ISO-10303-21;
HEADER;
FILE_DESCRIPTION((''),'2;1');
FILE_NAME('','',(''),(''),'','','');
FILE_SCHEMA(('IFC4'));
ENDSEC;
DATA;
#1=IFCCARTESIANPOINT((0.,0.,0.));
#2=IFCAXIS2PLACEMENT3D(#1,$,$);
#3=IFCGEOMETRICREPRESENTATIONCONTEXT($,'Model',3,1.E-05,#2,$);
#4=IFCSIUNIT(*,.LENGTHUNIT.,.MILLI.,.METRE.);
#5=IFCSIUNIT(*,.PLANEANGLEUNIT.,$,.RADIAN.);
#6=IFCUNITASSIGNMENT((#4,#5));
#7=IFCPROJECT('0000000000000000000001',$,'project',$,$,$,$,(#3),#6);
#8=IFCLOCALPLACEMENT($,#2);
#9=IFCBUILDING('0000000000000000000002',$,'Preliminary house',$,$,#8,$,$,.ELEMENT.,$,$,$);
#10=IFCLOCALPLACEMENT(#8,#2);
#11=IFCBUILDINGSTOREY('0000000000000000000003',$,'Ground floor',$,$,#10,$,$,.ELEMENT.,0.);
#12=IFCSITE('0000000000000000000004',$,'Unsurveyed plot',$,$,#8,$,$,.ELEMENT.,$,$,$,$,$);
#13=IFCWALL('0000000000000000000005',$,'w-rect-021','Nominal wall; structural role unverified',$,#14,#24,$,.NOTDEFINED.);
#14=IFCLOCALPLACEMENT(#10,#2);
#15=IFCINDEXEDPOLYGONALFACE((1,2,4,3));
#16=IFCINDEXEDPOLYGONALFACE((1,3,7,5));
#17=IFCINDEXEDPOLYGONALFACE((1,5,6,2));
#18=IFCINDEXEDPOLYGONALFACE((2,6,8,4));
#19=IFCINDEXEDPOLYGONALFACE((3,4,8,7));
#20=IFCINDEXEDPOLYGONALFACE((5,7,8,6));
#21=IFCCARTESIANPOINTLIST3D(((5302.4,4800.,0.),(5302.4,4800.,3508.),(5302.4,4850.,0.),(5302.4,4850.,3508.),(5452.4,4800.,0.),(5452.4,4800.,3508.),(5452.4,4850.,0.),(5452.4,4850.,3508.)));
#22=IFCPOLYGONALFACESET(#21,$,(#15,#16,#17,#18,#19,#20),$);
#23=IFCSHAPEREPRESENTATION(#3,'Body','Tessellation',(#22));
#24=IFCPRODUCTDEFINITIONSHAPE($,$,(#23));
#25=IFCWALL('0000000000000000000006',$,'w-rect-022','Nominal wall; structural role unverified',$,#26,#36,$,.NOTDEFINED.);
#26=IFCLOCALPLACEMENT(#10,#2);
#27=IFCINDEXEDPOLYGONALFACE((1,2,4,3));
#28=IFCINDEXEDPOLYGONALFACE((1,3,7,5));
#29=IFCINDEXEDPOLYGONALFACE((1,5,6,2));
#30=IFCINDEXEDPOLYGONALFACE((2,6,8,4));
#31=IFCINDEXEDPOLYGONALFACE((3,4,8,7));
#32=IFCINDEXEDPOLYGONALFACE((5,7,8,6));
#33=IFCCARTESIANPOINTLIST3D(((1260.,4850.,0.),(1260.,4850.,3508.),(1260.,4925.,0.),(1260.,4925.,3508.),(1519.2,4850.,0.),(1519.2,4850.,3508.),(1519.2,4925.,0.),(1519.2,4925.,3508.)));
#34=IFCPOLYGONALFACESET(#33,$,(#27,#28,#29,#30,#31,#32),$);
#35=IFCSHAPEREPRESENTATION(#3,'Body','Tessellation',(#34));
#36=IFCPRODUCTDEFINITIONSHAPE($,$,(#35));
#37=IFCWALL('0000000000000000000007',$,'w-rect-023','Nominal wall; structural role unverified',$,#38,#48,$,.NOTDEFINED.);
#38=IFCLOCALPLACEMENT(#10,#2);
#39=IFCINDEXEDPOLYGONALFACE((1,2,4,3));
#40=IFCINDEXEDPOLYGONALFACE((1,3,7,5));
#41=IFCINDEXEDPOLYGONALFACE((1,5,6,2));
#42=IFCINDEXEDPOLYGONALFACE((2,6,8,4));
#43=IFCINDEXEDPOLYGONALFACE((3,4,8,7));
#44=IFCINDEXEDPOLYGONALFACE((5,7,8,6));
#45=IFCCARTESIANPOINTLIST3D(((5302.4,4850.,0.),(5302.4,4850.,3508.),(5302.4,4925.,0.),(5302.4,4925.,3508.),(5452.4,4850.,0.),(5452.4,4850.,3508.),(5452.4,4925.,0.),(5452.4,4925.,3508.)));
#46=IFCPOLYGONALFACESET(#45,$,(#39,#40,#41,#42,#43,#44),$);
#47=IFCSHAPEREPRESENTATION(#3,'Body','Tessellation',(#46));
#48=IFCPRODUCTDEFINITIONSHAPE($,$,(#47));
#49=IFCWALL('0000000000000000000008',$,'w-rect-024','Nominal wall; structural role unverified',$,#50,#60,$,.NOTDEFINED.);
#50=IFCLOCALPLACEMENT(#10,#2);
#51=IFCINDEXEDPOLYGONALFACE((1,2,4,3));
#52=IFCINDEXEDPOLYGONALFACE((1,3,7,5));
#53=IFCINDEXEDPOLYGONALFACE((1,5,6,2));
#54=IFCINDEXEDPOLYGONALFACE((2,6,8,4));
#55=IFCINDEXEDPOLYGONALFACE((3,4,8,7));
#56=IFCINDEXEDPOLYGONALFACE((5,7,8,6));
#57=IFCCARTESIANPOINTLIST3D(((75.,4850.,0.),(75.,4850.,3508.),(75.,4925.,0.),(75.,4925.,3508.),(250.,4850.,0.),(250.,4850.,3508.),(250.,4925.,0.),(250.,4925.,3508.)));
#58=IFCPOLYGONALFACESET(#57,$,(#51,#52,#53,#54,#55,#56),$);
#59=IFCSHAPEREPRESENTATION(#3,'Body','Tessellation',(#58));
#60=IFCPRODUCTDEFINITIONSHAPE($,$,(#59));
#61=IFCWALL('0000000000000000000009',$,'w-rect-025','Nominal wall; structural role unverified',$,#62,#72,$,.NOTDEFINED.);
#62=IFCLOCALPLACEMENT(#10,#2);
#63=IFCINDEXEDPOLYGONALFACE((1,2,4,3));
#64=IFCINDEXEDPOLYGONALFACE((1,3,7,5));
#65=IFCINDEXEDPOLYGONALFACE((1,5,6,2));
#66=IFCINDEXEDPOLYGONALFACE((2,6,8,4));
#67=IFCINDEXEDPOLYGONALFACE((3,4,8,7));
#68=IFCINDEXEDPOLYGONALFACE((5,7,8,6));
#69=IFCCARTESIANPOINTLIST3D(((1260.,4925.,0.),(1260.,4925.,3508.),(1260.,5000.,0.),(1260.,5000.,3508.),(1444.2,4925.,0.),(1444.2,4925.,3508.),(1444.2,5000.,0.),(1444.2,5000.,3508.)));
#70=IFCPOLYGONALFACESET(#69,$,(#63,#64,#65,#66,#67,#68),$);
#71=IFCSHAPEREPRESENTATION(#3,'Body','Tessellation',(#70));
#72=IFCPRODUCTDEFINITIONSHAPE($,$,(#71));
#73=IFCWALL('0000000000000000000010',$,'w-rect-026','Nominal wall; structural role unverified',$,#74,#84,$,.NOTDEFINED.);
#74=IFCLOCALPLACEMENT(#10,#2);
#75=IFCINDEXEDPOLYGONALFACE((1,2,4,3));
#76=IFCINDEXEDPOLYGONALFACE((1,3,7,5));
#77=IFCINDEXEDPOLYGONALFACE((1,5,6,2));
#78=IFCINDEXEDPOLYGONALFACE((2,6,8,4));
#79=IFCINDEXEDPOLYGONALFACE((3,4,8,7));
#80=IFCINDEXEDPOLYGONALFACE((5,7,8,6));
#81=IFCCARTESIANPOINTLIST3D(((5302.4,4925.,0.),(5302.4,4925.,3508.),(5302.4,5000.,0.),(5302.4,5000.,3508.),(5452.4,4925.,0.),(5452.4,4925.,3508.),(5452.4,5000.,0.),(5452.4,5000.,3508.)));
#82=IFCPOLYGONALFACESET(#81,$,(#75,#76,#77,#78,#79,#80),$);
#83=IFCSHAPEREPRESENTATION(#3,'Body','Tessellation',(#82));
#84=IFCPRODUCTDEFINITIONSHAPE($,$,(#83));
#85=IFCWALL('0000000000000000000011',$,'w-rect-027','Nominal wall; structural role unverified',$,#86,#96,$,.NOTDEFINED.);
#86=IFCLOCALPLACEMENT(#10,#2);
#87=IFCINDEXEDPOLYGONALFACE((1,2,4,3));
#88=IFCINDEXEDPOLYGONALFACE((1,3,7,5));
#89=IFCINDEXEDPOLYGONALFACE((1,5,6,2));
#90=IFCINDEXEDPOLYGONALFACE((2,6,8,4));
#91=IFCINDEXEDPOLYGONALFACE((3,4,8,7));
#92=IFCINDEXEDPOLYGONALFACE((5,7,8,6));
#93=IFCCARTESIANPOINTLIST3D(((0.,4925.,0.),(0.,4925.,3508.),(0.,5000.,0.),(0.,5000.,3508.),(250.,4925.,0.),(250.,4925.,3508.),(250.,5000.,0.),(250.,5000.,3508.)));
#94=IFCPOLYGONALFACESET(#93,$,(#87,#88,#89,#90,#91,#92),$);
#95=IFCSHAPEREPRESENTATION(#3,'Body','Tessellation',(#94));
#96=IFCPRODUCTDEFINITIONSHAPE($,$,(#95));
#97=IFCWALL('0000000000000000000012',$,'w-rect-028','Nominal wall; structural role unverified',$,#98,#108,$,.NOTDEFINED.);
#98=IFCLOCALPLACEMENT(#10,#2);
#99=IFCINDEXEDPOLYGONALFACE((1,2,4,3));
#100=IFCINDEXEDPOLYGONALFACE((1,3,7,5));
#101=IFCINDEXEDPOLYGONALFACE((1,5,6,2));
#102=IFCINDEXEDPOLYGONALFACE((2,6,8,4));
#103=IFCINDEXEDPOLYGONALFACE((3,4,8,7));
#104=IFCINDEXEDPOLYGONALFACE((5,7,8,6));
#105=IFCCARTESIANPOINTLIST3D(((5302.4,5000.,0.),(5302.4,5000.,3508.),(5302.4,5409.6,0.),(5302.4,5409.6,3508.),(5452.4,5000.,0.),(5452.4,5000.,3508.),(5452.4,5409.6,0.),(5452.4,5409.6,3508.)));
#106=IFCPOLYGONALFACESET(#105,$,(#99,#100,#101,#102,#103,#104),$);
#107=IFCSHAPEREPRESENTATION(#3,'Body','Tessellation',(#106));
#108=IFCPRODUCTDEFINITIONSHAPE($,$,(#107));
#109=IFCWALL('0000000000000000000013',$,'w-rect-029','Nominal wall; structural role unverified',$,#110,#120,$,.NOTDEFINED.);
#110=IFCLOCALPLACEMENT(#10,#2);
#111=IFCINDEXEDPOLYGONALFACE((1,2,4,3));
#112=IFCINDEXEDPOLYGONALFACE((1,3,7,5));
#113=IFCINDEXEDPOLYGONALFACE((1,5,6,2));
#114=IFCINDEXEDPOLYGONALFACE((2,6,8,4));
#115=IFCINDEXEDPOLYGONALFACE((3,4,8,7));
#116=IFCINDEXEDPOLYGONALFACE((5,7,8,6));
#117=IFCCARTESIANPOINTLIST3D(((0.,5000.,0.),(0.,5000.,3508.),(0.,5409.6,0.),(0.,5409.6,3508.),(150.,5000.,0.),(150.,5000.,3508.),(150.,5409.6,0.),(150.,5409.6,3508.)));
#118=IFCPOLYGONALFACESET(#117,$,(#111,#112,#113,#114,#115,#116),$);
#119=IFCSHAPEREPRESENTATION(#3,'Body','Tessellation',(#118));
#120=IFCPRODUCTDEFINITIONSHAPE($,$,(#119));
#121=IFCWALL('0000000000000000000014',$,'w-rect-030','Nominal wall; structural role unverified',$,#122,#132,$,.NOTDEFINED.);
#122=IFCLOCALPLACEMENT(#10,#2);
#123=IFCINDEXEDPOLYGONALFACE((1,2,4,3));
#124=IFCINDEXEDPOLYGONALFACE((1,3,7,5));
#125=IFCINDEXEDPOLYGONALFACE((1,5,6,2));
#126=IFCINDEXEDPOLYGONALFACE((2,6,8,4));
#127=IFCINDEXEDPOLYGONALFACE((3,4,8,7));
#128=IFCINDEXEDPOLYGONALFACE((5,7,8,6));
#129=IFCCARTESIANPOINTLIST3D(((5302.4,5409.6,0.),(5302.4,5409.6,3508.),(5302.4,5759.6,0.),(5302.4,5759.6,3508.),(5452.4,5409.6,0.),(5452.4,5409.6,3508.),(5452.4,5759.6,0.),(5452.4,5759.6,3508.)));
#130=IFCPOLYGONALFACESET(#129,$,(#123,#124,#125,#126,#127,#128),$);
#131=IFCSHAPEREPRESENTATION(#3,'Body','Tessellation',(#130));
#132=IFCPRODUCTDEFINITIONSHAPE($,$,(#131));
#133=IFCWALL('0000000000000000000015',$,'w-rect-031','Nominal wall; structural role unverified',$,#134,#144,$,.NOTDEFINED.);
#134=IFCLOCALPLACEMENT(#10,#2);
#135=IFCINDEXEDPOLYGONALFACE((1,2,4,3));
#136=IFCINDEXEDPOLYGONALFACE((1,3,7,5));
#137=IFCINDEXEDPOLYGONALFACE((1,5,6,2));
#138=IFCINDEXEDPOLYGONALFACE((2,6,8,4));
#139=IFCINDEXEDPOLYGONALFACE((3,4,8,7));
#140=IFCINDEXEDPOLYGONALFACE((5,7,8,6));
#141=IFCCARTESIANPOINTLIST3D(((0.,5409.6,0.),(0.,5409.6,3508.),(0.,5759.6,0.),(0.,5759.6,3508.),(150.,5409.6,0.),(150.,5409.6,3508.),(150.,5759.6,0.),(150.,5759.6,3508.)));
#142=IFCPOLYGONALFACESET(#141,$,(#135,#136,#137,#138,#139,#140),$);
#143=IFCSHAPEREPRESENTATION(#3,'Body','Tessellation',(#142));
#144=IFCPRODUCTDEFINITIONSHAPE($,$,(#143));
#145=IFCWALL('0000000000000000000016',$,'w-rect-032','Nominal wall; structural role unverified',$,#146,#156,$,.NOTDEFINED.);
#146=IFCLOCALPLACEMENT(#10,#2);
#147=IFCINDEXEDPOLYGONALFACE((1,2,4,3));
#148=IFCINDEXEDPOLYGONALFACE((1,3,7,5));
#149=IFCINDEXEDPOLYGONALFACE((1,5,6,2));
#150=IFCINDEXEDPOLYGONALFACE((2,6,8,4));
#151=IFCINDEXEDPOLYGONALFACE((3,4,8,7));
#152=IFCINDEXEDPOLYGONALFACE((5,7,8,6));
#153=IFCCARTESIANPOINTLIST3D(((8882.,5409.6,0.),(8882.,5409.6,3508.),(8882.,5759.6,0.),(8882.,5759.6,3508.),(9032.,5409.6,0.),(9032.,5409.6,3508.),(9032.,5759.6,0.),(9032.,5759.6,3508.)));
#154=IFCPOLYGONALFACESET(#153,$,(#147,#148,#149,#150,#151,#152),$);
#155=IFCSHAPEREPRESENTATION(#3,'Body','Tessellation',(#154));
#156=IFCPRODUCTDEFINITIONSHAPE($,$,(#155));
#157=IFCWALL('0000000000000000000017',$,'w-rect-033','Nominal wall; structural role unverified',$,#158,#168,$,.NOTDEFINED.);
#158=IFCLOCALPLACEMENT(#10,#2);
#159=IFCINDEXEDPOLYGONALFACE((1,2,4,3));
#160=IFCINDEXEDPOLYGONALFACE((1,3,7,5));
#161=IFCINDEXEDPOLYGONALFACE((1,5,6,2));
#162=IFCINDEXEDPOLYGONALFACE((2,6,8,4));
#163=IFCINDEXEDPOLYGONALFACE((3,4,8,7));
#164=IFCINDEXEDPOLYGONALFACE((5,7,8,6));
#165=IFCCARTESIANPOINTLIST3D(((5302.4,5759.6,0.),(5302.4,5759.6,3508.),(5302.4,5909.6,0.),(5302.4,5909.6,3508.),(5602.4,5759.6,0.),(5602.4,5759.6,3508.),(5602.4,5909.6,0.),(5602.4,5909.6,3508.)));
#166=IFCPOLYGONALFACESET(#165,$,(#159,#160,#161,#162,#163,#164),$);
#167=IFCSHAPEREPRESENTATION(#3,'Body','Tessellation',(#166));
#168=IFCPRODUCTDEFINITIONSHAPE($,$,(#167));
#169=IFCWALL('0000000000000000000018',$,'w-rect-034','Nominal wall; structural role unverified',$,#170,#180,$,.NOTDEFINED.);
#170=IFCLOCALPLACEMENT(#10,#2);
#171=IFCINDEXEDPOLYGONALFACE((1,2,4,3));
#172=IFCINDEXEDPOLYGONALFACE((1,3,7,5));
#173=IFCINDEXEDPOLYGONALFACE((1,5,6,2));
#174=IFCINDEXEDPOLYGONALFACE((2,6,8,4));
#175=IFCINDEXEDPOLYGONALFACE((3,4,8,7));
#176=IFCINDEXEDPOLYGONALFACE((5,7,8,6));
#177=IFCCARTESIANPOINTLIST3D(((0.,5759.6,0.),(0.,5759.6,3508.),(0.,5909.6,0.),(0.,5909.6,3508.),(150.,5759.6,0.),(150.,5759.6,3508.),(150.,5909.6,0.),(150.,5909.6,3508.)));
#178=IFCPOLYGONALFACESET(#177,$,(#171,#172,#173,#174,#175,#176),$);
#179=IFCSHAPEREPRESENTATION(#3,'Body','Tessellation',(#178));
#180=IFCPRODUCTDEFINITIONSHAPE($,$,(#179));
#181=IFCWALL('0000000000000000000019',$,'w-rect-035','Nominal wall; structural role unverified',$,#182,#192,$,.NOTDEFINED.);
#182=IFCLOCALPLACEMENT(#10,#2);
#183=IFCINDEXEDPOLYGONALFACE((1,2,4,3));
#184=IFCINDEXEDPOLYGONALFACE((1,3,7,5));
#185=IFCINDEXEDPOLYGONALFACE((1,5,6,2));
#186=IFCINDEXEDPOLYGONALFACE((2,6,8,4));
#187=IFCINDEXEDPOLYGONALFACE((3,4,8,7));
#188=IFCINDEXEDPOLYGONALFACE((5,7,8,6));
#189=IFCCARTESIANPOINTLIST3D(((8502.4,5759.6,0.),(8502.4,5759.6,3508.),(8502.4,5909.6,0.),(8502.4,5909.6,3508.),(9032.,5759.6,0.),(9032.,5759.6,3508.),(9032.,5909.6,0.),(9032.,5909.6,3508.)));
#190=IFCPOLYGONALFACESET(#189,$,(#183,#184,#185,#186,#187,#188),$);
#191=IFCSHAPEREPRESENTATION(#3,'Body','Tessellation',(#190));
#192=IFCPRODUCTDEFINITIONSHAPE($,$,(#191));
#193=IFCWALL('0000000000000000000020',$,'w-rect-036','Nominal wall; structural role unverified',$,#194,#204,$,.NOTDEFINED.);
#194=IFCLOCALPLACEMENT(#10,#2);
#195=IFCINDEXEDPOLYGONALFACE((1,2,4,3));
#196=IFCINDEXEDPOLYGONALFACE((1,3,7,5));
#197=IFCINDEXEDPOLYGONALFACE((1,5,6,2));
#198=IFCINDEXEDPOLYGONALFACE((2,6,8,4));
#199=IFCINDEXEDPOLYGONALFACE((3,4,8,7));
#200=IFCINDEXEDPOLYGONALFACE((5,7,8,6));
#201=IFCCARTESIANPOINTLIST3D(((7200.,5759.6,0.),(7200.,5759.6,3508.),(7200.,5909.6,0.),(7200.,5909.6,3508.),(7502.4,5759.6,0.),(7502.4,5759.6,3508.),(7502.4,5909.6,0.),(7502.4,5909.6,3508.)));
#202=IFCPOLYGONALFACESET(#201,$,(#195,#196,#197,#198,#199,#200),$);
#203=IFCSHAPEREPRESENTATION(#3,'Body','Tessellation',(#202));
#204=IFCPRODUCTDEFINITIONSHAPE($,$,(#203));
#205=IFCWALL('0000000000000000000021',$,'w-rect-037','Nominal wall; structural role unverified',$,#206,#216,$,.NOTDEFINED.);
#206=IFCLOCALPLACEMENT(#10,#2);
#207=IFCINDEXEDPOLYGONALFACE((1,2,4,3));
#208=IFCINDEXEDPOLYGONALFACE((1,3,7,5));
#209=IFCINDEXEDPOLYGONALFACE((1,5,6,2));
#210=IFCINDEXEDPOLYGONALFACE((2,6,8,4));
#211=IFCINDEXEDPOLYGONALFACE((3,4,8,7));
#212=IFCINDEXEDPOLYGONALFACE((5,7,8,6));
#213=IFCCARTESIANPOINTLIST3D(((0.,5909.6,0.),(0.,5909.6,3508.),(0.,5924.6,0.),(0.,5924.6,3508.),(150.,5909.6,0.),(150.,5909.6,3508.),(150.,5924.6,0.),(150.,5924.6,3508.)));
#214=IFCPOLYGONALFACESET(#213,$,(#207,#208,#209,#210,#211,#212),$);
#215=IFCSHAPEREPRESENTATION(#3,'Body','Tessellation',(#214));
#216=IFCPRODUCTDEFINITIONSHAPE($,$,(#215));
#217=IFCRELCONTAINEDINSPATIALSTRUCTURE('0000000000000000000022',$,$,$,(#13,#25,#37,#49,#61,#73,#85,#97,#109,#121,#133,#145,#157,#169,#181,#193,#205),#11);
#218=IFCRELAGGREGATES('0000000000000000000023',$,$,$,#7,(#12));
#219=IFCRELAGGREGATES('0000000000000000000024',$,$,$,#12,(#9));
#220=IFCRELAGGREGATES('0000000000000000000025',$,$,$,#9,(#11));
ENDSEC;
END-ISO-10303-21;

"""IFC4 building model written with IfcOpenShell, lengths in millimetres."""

from ifc_helpers import new_model, si_unit, origin, place, context, project, spatial, polyline, outline, extrude, element, save


model = new_model("IFC4")

# Units and contexts
model_context = context("Model", 3, precision=1e-05, world=origin())
ifc_project = project(units=[si_unit("LENGTHUNIT", "METRE", prefix="MILLI"), si_unit("PLANEANGLEUNIT", "RADIAN")], contexts=[model_context])

# Site, building, storey
placement_1 = place(None, origin())
site = spatial("IfcSite", under=ifc_project, at=placement_1, Name="Unsurveyed plot", CompositionType="ELEMENT")
building = spatial("IfcBuilding", under=site, at=placement_1, Name="Preliminary house", CompositionType="ELEMENT")
placement_2 = place(placement_1, origin())
storey = spatial("IfcBuildingStorey", under=building, at=placement_2, Name="Ground floor", CompositionType="ELEMENT", Elevation=0.0)

# Walls
element("IfcWall", 1, at=placement_2, inside=storey, Name="w-rect-021", Description="Nominal wall; structural role unverified", PredefinedType="NOTDEFINED", context=model_context, shape_type="SweptSolid", body=[
    extrude(outline(polyline([(5302.4, 4800.0), (5452.4, 4800.0), (5452.4, 4850.0), (5302.4, 4850.0), (5302.4, 4800.0)])), origin(), (0.0, 0.0, 1.0), 3508.0),
])
element("IfcWall", 2, at=placement_2, inside=storey, Name="w-rect-022", Description="Nominal wall; structural role unverified", PredefinedType="NOTDEFINED", context=model_context, shape_type="SweptSolid", body=[
    extrude(outline(polyline([(1260.0, 4850.0), (1519.2, 4850.0), (1519.2, 4925.0), (1260.0, 4925.0), (1260.0, 4850.0)])), origin(), (0.0, 0.0, 1.0), 3508.0),
])
element("IfcWall", 3, at=placement_2, inside=storey, Name="w-rect-023", Description="Nominal wall; structural role unverified", PredefinedType="NOTDEFINED", context=model_context, shape_type="SweptSolid", body=[
    extrude(outline(polyline([(5302.4, 4850.0), (5452.4, 4850.0), (5452.4, 4925.0), (5302.4, 4925.0), (5302.4, 4850.0)])), origin(), (0.0, 0.0, 1.0), 3508.0),
])
element("IfcWall", 4, at=placement_2, inside=storey, Name="w-rect-024", Description="Nominal wall; structural role unverified", PredefinedType="NOTDEFINED", context=model_context, shape_type="SweptSolid", body=[
    extrude(outline(polyline([(75.0, 4850.0), (250.0, 4850.0), (250.0, 4925.0), (75.0, 4925.0), (75.0, 4850.0)])), origin(), (0.0, 0.0, 1.0), 3508.0),
])
element("IfcWall", 5, at=placement_2, inside=storey, Name="w-rect-025", Description="Nominal wall; structural role unverified", PredefinedType="NOTDEFINED", context=model_context, shape_type="SweptSolid", body=[
    extrude(outline(polyline([(1260.0, 4925.0), (1444.2, 4925.0), (1444.2, 5000.0), (1260.0, 5000.0), (1260.0, 4925.0)])), origin(), (0.0, 0.0, 1.0), 3508.0),
])
element("IfcWall", 6, at=placement_2, inside=storey, Name="w-rect-026", Description="Nominal wall; structural role unverified", PredefinedType="NOTDEFINED", context=model_context, shape_type="SweptSolid", body=[
    extrude(outline(polyline([(5302.4, 4925.0), (5452.4, 4925.0), (5452.4, 5000.0), (5302.4, 5000.0), (5302.4, 4925.0)])), origin(), (0.0, 0.0, 1.0), 3508.0),
])
element("IfcWall", 7, at=placement_2, inside=storey, Name="w-rect-027", Description="Nominal wall; structural role unverified", PredefinedType="NOTDEFINED", context=model_context, shape_type="SweptSolid", body=[
    extrude(outline(polyline([(0.0, 4925.0), (250.0, 4925.0), (250.0, 5000.0), (0.0, 5000.0), (0.0, 4925.0)])), origin(), (0.0, 0.0, 1.0), 3508.0),
])
element("IfcWall", 8, at=placement_2, inside=storey, Name="w-rect-028", Description="Nominal wall; structural role unverified", PredefinedType="NOTDEFINED", context=model_context, shape_type="SweptSolid", body=[
    extrude(outline(polyline([(5302.4, 5000.0), (5452.4, 5000.0), (5452.4, 5409.6), (5302.4, 5409.6), (5302.4, 5000.0)])), origin(), (0.0, 0.0, 1.0), 3508.0),
])
element("IfcWall", 9, at=placement_2, inside=storey, Name="w-rect-029", Description="Nominal wall; structural role unverified", PredefinedType="NOTDEFINED", context=model_context, shape_type="SweptSolid", body=[
    extrude(outline(polyline([(0.0, 5000.0), (150.0, 5000.0), (150.0, 5409.6), (0.0, 5409.6), (0.0, 5000.0)])), origin(), (0.0, 0.0, 1.0), 3508.0),
])
element("IfcWall", 10, at=placement_2, inside=storey, Name="w-rect-030", Description="Nominal wall; structural role unverified", PredefinedType="NOTDEFINED", context=model_context, shape_type="SweptSolid", body=[
    extrude(outline(polyline([(5302.4, 5409.6), (5452.4, 5409.6), (5452.4, 5759.6), (5302.4, 5759.6), (5302.4, 5409.6)])), origin(), (0.0, 0.0, 1.0), 3508.0),
])
element("IfcWall", 11, at=placement_2, inside=storey, Name="w-rect-031", Description="Nominal wall; structural role unverified", PredefinedType="NOTDEFINED", context=model_context, shape_type="SweptSolid", body=[
    extrude(outline(polyline([(0.0, 5409.6), (150.0, 5409.6), (150.0, 5759.6), (0.0, 5759.6), (0.0, 5409.6)])), origin(), (0.0, 0.0, 1.0), 3508.0),
])
element("IfcWall", 12, at=placement_2, inside=storey, Name="w-rect-032", Description="Nominal wall; structural role unverified", PredefinedType="NOTDEFINED", context=model_context, shape_type="SweptSolid", body=[
    extrude(outline(polyline([(8882.0, 5409.6), (9032.0, 5409.6), (9032.0, 5759.6), (8882.0, 5759.6), (8882.0, 5409.6)])), origin(), (0.0, 0.0, 1.0), 3508.0),
])
element("IfcWall", 13, at=placement_2, inside=storey, Name="w-rect-033", Description="Nominal wall; structural role unverified", PredefinedType="NOTDEFINED", context=model_context, shape_type="SweptSolid", body=[
    extrude(outline(polyline([(5302.4, 5759.6), (5602.4, 5759.6), (5602.4, 5909.6), (5302.4, 5909.6), (5302.4, 5759.6)])), origin(), (0.0, 0.0, 1.0), 3508.0),
])
element("IfcWall", 14, at=placement_2, inside=storey, Name="w-rect-034", Description="Nominal wall; structural role unverified", PredefinedType="NOTDEFINED", context=model_context, shape_type="SweptSolid", body=[
    extrude(outline(polyline([(0.0, 5759.6), (150.0, 5759.6), (150.0, 5909.6), (0.0, 5909.6), (0.0, 5759.6)])), origin(), (0.0, 0.0, 1.0), 3508.0),
])
element("IfcWall", 15, at=placement_2, inside=storey, Name="w-rect-035", Description="Nominal wall; structural role unverified", PredefinedType="NOTDEFINED", context=model_context, shape_type="SweptSolid", body=[
    extrude(outline(polyline([(8502.4, 5759.6), (9032.0, 5759.6), (9032.0, 5909.6), (8502.4, 5909.6), (8502.4, 5759.6)])), origin(), (0.0, 0.0, 1.0), 3508.0),
])
element("IfcWall", 16, at=placement_2, inside=storey, Name="w-rect-036", Description="Nominal wall; structural role unverified", PredefinedType="NOTDEFINED", context=model_context, shape_type="SweptSolid", body=[
    extrude(outline(polyline([(7200.0, 5759.6), (7502.4, 5759.6), (7502.4, 5909.6), (7200.0, 5909.6), (7200.0, 5759.6)])), origin(), (0.0, 0.0, 1.0), 3508.0),
])
element("IfcWall", 17, at=placement_2, inside=storey, Name="w-rect-037", Description="Nominal wall; structural role unverified", PredefinedType="NOTDEFINED", context=model_context, shape_type="SweptSolid", body=[
    extrude(outline(polyline([(0.0, 5909.6), (150.0, 5909.6), (150.0, 5924.6), (0.0, 5924.6), (0.0, 5909.6)])), origin(), (0.0, 0.0, 1.0), 3508.0),
])

save(model, "model.ifc")
